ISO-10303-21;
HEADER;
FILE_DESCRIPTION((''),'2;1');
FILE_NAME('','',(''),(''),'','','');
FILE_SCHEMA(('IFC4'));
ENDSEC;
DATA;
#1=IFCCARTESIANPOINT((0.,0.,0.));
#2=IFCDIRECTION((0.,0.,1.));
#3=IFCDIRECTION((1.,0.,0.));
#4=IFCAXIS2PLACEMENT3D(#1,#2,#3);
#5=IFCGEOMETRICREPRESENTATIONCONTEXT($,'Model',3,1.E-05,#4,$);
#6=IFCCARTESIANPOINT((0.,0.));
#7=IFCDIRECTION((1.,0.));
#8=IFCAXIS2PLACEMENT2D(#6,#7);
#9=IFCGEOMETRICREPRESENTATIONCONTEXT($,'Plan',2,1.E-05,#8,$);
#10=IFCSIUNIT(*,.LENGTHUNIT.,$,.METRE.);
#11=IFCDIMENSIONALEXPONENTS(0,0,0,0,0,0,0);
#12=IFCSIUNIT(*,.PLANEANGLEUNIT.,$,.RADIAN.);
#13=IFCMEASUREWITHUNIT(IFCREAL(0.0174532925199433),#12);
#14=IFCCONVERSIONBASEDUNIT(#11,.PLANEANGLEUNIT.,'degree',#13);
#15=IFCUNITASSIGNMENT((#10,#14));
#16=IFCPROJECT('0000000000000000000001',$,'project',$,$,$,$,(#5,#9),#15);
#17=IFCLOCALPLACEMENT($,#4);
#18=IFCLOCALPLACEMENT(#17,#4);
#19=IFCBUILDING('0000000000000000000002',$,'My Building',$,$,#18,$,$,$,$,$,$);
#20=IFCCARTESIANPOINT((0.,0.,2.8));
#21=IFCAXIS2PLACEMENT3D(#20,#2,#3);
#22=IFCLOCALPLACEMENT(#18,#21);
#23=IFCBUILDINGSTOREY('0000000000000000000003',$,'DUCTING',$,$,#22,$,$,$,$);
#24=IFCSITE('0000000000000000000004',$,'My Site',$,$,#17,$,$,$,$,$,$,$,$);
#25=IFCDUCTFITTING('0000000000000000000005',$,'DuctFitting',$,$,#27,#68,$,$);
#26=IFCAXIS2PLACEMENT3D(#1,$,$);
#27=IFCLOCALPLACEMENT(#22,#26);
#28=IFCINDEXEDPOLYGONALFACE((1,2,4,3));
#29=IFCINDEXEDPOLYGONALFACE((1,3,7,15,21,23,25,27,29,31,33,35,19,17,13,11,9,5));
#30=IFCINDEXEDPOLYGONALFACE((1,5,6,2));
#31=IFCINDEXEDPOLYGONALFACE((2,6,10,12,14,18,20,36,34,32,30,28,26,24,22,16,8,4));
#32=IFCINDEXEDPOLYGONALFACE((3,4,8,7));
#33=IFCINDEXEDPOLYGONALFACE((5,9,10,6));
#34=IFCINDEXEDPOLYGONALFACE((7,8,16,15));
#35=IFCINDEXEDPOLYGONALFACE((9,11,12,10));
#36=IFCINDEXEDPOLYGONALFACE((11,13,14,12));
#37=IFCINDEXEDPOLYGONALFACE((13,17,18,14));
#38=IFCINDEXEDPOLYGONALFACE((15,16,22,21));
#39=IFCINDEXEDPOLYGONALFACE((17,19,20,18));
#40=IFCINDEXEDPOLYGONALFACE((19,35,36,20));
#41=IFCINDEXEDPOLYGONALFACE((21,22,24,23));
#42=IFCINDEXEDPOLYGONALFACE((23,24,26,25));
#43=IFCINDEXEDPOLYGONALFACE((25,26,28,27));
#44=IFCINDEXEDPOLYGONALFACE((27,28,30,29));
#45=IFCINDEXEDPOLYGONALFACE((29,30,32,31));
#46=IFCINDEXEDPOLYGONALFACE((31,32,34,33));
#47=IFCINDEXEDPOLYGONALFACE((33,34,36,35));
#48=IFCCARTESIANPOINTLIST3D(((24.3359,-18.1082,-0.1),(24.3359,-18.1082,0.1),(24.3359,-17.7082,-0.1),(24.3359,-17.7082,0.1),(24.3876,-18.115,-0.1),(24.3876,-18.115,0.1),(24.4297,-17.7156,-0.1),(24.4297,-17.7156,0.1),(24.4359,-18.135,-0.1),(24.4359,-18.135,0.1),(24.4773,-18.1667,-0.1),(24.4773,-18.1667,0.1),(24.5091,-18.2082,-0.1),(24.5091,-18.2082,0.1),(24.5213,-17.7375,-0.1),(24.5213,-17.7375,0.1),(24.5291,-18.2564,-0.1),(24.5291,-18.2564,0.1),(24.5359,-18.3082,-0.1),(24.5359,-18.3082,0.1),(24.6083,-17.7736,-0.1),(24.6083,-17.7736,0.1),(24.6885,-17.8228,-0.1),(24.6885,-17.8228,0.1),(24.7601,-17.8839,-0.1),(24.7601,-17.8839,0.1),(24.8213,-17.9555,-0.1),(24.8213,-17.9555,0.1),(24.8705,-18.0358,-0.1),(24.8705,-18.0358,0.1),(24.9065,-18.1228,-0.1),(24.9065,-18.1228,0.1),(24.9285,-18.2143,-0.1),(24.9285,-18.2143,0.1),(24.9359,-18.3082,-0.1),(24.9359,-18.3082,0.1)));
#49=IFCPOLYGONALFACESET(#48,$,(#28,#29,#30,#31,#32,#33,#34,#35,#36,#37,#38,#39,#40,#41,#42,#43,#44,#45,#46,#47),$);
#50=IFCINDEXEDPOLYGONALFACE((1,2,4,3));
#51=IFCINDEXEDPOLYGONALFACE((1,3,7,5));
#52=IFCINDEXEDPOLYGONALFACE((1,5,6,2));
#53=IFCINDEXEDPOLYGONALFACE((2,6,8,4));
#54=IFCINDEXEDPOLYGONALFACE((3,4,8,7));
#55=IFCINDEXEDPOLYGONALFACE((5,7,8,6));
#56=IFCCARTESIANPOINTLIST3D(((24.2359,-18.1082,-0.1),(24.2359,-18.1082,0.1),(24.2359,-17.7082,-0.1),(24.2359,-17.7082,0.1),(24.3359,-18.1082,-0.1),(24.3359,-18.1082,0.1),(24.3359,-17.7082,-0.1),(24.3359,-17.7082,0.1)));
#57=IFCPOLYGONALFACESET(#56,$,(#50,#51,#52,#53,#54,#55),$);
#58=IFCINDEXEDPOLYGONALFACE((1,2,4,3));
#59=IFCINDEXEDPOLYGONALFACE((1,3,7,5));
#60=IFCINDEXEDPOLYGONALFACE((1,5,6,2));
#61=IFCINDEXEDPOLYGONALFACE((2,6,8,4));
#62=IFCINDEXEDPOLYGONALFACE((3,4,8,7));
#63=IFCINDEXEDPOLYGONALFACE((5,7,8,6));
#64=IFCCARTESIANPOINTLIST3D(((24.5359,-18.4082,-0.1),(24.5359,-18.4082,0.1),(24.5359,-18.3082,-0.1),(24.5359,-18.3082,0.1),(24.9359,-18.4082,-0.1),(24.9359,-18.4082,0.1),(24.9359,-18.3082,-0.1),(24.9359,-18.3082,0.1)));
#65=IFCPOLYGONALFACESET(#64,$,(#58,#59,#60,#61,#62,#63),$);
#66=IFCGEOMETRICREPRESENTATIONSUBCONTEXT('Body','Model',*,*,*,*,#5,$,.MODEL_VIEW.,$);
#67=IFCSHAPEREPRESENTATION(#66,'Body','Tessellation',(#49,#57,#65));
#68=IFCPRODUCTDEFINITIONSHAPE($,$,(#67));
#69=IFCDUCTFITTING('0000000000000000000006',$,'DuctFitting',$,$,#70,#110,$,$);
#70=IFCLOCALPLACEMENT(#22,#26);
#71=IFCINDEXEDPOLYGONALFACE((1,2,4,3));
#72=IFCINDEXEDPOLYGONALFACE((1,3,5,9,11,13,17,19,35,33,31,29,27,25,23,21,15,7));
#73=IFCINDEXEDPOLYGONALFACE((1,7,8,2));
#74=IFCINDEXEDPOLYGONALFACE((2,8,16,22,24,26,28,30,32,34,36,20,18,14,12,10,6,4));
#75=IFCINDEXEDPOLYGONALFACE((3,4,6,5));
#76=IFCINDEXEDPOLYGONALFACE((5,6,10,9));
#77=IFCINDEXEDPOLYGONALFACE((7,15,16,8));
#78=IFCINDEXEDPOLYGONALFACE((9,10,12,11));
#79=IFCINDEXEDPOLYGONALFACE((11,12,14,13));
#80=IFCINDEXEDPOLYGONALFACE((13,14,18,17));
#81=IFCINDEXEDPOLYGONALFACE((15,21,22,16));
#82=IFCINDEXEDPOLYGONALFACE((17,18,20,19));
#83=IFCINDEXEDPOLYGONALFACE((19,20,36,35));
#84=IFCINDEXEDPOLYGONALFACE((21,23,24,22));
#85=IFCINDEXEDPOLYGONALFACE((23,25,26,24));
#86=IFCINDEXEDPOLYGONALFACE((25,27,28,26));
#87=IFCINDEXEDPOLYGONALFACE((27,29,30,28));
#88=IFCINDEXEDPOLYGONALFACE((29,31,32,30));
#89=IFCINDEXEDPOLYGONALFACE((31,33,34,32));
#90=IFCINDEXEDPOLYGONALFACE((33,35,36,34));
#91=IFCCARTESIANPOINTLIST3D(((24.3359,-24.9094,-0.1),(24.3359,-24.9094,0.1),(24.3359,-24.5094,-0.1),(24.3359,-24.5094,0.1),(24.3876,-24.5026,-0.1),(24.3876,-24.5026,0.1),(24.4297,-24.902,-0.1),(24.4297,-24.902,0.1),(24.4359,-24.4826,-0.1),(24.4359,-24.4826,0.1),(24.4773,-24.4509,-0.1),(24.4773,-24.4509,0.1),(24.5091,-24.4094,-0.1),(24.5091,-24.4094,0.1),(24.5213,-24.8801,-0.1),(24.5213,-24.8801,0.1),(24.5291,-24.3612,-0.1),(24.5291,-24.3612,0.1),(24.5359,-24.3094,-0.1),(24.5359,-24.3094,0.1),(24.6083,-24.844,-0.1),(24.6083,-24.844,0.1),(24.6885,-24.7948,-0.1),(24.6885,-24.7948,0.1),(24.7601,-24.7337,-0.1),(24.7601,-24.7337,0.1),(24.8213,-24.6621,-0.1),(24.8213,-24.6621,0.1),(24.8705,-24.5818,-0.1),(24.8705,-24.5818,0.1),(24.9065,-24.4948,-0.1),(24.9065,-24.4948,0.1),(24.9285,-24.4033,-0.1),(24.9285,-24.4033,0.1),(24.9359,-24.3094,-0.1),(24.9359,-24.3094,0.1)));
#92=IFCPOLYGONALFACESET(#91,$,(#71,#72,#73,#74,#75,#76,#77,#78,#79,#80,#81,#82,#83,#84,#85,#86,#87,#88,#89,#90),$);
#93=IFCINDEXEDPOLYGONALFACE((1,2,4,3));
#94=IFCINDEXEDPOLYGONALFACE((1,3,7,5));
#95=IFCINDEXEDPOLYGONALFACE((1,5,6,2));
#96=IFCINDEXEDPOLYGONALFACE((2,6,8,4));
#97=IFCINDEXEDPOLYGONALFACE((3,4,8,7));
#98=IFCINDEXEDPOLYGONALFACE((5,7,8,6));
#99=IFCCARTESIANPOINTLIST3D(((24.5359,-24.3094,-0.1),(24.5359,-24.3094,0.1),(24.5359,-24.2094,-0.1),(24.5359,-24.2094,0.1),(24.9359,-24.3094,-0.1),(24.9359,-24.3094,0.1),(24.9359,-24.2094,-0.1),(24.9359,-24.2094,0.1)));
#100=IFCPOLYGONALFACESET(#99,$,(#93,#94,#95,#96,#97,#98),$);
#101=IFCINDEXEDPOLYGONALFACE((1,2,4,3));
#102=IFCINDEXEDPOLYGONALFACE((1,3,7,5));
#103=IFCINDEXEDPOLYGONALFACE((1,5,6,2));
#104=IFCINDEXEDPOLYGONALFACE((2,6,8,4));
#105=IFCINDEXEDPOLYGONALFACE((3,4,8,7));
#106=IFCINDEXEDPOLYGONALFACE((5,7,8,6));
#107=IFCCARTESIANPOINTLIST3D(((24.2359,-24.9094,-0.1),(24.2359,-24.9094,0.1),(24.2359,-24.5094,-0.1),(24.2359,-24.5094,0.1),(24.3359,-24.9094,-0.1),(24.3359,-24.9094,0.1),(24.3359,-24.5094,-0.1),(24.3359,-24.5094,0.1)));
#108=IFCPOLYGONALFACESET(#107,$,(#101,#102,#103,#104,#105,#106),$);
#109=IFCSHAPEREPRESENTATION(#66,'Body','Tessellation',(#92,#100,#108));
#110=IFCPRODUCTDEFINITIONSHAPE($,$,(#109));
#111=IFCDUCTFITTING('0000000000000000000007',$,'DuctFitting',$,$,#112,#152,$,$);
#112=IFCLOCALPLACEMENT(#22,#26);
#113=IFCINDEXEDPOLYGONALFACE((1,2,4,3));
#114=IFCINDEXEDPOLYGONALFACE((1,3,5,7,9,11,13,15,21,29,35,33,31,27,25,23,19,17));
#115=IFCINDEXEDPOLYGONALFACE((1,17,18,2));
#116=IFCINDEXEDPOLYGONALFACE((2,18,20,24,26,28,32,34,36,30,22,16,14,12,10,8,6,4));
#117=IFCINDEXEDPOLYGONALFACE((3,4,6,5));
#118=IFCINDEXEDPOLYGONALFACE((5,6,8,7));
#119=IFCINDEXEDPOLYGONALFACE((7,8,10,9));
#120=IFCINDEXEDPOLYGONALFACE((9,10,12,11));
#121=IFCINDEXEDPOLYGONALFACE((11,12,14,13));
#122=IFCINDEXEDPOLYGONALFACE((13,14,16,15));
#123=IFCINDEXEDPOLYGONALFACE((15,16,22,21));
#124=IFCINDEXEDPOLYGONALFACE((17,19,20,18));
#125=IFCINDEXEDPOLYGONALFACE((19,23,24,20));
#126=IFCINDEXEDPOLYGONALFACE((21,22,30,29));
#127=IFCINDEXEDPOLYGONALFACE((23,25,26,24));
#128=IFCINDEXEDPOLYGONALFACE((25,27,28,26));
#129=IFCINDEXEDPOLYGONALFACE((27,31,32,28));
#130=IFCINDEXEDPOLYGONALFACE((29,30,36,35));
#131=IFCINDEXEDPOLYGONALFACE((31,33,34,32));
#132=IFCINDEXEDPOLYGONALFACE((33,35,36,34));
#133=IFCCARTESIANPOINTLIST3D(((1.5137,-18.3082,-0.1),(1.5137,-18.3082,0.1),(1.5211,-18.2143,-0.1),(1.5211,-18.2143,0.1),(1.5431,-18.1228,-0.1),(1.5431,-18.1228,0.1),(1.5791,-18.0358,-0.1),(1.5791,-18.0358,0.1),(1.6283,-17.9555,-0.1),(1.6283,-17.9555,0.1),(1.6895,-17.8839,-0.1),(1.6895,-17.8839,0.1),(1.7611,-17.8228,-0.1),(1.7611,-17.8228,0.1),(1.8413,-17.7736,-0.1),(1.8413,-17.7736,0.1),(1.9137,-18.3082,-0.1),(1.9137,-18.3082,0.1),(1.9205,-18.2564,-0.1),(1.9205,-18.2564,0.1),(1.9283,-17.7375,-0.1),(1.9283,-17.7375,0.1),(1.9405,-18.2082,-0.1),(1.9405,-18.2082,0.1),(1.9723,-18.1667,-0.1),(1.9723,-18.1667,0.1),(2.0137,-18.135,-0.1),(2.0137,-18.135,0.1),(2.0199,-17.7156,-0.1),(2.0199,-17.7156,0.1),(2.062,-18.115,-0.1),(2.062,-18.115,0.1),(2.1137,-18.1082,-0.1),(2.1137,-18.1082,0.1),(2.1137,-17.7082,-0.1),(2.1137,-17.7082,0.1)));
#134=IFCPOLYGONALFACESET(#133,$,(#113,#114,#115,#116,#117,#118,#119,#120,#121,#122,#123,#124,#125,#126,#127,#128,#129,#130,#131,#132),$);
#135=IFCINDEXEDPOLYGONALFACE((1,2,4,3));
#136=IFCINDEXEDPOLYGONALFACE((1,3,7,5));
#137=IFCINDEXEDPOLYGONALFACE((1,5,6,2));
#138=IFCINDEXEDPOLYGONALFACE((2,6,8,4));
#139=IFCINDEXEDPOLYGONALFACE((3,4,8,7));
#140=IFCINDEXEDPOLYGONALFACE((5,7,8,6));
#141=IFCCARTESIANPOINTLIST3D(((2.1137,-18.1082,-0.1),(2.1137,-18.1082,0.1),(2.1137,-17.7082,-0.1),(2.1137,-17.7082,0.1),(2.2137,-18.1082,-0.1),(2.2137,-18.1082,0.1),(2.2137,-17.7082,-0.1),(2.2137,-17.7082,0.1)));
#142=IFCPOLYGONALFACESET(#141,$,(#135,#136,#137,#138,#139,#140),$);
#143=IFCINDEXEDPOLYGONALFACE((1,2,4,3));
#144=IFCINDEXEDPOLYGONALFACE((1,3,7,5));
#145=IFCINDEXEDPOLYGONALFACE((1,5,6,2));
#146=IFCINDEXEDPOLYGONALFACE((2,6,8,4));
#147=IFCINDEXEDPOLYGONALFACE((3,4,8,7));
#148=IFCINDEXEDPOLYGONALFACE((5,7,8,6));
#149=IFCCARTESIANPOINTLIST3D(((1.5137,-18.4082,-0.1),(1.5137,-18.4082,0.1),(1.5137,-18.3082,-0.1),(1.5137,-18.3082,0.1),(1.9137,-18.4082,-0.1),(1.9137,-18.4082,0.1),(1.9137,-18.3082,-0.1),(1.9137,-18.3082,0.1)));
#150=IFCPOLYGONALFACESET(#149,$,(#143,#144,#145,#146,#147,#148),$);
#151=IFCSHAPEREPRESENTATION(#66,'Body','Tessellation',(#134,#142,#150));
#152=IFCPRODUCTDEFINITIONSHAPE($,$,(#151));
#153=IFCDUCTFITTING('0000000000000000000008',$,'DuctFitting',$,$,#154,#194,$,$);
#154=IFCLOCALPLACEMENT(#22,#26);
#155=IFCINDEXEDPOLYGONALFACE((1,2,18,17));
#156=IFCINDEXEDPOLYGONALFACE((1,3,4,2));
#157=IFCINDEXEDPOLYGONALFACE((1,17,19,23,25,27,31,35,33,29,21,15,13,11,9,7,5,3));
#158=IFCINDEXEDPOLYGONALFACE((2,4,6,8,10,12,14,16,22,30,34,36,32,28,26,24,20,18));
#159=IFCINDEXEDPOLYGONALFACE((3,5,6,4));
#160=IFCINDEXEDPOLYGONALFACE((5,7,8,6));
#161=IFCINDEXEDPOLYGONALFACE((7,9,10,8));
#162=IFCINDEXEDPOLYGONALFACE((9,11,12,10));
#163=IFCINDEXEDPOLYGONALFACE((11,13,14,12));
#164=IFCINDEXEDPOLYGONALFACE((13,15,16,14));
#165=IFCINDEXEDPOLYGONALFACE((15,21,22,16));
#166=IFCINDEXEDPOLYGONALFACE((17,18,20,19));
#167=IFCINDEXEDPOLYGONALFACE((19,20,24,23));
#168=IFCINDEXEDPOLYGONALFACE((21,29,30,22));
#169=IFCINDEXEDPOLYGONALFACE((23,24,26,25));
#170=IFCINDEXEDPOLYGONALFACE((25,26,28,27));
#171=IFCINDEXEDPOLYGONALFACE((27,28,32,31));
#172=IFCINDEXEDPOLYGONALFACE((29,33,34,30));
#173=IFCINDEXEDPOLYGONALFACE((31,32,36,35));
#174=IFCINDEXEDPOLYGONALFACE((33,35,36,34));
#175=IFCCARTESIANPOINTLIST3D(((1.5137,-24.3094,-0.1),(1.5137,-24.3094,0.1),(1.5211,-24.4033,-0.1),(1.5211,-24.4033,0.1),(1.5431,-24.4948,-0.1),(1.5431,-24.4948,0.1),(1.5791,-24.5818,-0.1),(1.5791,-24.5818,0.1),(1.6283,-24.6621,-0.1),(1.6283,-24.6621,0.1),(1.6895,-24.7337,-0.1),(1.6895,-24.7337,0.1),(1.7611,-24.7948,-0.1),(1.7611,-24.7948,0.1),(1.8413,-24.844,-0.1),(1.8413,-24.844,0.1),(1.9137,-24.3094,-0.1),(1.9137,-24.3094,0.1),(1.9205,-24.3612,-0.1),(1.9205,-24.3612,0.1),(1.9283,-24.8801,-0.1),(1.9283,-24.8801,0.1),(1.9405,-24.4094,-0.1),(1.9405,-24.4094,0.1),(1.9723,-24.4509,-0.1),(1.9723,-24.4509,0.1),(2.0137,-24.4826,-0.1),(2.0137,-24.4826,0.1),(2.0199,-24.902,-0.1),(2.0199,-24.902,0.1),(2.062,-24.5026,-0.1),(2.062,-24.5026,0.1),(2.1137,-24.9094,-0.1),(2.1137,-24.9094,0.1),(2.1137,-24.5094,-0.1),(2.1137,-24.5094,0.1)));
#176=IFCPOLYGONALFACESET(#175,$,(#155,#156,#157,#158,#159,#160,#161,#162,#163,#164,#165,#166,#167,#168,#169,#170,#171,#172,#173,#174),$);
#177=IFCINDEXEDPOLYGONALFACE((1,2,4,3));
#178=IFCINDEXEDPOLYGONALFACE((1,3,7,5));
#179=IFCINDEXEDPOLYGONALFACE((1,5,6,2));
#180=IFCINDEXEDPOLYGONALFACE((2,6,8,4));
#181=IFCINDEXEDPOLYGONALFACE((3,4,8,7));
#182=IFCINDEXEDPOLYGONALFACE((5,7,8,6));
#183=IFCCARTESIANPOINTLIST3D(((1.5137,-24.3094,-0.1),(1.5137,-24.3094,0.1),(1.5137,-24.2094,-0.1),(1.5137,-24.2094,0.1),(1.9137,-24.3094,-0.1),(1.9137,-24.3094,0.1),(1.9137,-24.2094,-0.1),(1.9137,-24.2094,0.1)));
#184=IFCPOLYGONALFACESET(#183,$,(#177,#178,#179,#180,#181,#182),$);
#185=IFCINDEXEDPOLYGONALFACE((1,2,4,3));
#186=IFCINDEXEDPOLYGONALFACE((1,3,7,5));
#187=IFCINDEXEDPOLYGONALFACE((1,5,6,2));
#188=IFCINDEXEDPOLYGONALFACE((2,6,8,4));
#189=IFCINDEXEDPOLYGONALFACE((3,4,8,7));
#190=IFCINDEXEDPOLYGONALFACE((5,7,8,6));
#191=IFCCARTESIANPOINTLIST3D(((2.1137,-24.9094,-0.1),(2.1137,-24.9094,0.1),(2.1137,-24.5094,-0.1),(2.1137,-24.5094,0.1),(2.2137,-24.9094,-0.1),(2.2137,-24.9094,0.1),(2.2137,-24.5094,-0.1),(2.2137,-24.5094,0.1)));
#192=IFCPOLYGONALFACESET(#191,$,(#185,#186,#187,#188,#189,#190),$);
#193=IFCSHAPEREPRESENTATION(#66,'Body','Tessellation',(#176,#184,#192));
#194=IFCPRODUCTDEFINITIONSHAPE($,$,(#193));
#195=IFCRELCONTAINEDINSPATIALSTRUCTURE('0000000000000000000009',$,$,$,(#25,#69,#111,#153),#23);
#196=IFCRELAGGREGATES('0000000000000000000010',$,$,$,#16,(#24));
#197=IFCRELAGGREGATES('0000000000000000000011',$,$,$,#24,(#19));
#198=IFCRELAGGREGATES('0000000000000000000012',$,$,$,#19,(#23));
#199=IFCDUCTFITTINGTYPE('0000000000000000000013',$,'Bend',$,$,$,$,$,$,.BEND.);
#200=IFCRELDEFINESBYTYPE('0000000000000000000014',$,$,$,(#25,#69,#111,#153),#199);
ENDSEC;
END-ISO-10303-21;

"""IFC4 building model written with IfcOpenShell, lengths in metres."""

from ifc_helpers import new_model, entity, si_unit, converted_unit, frame, origin_with_axes, origin_2d_with_axis, place, context, subcontext, project, spatial, line, arc, indexed_curve, rectangle, outline, extrude, source, transform, mapped, type_object, type_shapes, element, save


model = new_model("IFC4")

# Units and contexts
model_context = context("Model", 3, precision=1e-05, world=origin_with_axes())
plan_context = context("Plan", 2, precision=1e-05, world=origin_2d_with_axis())
body_context = subcontext(model_context, "Body", "Model", "MODEL_VIEW")
ifc_project = project(units=[si_unit("LENGTHUNIT", "METRE"), converted_unit("PLANEANGLEUNIT", "degree", entity("IfcReal", 0.0174532925199433), si_unit("PLANEANGLEUNIT", "RADIAN"), dimensions=[0, 0, 0, 0, 0, 0, 0])], contexts=[model_context, plan_context])

# Site, building, storey
site_placement = place(None, origin_with_axes())
site = spatial("IfcSite", under=ifc_project, at=site_placement, Name="My Site")
building_placement = place(site_placement, origin_with_axes())
building = spatial("IfcBuilding", under=site, at=building_placement, Name="My Building")
storey_placement = place(building_placement, frame((0.0, 0.0, 2.8), z_axis=(0.0, 0.0, 1.0), x_axis=(1.0, 0.0, 0.0)))
storey = spatial("IfcBuildingStorey", under=building, at=storey_placement, Name="DUCTING")

# Duct fittings
duct_fitting_type = type_object("IfcDuctFittingType", Name="Bend", PredefinedType="BEND")
shared_shape = source(origin_with_axes(), body_context, "Body", "SweptSolid", [
    extrude(outline(indexed_curve([(-0.2, 0.0), (-0.2586, 0.1414), (-0.4, 0.2), (-0.4, 0.6), (0.0243, 0.4243), (0.2, 0.0)], segments=[arc(1, 2, 3), line(3, 4), arc(4, 5, 6), line(6, 1)])), frame((0.0, -0.1, 0.1), z_axis=(0.0, -1.0, 0.0), x_axis=(1.0, 0.0, 0.0)), (0.0, 0.0, -1.0), 0.2),
    extrude(rectangle(XDim=0.4, YDim=0.2), origin_with_axes(), (0.0, 0.0, 1.0), 0.1),
    extrude(rectangle(XDim=0.4, YDim=0.2), frame((-0.4, 0.0, 0.5), z_axis=(-1.0, 0.0, 0.0), x_axis=(0.0, 0.0, -1.0)), (0.0, 0.0, 1.0), 0.1),
])
type_shapes(duct_fitting_type, [shared_shape])
for number, where, z_axis, x_axis, name in (
    (1, (24.2359, -17.9082, 0.0), (1.0, 0.0, 0.0), (0.0, 1.0, 0.0), "DuctFitting"),
    (2, (24.7359, -24.2094, 0.0), (0.0, -1.0, 0.0), (1.0, 0.0, 0.0), "DuctFitting"),
    (3, (2.2137, -17.9082, 0.0), (-1.0, 0.0, 0.0), (0.0, 1.0, 0.0), "DuctFitting"),
    (4, (1.7137, -24.2094, 0.0), (0.0, -1.0, 0.0), (-1.0, 0.0, 0.0), "DuctFitting"),
):
    element("IfcDuctFitting", number, at=place(storey_placement, frame(where, z_axis=z_axis, x_axis=x_axis)), inside=storey, type_object=duct_fitting_type, Name=name, context=body_context, shape_type="MappedRepresentation", body=[
        mapped(shared_shape, transform((0.0, 0.0, 0.0), x_axis=(1.0, 0.0, 0.0), y_axis=(0.0, 1.0, 0.0), z_axis=(0.0, 0.0, 1.0), scale=1.0)),
    ])

save(model, "model.ifc")
